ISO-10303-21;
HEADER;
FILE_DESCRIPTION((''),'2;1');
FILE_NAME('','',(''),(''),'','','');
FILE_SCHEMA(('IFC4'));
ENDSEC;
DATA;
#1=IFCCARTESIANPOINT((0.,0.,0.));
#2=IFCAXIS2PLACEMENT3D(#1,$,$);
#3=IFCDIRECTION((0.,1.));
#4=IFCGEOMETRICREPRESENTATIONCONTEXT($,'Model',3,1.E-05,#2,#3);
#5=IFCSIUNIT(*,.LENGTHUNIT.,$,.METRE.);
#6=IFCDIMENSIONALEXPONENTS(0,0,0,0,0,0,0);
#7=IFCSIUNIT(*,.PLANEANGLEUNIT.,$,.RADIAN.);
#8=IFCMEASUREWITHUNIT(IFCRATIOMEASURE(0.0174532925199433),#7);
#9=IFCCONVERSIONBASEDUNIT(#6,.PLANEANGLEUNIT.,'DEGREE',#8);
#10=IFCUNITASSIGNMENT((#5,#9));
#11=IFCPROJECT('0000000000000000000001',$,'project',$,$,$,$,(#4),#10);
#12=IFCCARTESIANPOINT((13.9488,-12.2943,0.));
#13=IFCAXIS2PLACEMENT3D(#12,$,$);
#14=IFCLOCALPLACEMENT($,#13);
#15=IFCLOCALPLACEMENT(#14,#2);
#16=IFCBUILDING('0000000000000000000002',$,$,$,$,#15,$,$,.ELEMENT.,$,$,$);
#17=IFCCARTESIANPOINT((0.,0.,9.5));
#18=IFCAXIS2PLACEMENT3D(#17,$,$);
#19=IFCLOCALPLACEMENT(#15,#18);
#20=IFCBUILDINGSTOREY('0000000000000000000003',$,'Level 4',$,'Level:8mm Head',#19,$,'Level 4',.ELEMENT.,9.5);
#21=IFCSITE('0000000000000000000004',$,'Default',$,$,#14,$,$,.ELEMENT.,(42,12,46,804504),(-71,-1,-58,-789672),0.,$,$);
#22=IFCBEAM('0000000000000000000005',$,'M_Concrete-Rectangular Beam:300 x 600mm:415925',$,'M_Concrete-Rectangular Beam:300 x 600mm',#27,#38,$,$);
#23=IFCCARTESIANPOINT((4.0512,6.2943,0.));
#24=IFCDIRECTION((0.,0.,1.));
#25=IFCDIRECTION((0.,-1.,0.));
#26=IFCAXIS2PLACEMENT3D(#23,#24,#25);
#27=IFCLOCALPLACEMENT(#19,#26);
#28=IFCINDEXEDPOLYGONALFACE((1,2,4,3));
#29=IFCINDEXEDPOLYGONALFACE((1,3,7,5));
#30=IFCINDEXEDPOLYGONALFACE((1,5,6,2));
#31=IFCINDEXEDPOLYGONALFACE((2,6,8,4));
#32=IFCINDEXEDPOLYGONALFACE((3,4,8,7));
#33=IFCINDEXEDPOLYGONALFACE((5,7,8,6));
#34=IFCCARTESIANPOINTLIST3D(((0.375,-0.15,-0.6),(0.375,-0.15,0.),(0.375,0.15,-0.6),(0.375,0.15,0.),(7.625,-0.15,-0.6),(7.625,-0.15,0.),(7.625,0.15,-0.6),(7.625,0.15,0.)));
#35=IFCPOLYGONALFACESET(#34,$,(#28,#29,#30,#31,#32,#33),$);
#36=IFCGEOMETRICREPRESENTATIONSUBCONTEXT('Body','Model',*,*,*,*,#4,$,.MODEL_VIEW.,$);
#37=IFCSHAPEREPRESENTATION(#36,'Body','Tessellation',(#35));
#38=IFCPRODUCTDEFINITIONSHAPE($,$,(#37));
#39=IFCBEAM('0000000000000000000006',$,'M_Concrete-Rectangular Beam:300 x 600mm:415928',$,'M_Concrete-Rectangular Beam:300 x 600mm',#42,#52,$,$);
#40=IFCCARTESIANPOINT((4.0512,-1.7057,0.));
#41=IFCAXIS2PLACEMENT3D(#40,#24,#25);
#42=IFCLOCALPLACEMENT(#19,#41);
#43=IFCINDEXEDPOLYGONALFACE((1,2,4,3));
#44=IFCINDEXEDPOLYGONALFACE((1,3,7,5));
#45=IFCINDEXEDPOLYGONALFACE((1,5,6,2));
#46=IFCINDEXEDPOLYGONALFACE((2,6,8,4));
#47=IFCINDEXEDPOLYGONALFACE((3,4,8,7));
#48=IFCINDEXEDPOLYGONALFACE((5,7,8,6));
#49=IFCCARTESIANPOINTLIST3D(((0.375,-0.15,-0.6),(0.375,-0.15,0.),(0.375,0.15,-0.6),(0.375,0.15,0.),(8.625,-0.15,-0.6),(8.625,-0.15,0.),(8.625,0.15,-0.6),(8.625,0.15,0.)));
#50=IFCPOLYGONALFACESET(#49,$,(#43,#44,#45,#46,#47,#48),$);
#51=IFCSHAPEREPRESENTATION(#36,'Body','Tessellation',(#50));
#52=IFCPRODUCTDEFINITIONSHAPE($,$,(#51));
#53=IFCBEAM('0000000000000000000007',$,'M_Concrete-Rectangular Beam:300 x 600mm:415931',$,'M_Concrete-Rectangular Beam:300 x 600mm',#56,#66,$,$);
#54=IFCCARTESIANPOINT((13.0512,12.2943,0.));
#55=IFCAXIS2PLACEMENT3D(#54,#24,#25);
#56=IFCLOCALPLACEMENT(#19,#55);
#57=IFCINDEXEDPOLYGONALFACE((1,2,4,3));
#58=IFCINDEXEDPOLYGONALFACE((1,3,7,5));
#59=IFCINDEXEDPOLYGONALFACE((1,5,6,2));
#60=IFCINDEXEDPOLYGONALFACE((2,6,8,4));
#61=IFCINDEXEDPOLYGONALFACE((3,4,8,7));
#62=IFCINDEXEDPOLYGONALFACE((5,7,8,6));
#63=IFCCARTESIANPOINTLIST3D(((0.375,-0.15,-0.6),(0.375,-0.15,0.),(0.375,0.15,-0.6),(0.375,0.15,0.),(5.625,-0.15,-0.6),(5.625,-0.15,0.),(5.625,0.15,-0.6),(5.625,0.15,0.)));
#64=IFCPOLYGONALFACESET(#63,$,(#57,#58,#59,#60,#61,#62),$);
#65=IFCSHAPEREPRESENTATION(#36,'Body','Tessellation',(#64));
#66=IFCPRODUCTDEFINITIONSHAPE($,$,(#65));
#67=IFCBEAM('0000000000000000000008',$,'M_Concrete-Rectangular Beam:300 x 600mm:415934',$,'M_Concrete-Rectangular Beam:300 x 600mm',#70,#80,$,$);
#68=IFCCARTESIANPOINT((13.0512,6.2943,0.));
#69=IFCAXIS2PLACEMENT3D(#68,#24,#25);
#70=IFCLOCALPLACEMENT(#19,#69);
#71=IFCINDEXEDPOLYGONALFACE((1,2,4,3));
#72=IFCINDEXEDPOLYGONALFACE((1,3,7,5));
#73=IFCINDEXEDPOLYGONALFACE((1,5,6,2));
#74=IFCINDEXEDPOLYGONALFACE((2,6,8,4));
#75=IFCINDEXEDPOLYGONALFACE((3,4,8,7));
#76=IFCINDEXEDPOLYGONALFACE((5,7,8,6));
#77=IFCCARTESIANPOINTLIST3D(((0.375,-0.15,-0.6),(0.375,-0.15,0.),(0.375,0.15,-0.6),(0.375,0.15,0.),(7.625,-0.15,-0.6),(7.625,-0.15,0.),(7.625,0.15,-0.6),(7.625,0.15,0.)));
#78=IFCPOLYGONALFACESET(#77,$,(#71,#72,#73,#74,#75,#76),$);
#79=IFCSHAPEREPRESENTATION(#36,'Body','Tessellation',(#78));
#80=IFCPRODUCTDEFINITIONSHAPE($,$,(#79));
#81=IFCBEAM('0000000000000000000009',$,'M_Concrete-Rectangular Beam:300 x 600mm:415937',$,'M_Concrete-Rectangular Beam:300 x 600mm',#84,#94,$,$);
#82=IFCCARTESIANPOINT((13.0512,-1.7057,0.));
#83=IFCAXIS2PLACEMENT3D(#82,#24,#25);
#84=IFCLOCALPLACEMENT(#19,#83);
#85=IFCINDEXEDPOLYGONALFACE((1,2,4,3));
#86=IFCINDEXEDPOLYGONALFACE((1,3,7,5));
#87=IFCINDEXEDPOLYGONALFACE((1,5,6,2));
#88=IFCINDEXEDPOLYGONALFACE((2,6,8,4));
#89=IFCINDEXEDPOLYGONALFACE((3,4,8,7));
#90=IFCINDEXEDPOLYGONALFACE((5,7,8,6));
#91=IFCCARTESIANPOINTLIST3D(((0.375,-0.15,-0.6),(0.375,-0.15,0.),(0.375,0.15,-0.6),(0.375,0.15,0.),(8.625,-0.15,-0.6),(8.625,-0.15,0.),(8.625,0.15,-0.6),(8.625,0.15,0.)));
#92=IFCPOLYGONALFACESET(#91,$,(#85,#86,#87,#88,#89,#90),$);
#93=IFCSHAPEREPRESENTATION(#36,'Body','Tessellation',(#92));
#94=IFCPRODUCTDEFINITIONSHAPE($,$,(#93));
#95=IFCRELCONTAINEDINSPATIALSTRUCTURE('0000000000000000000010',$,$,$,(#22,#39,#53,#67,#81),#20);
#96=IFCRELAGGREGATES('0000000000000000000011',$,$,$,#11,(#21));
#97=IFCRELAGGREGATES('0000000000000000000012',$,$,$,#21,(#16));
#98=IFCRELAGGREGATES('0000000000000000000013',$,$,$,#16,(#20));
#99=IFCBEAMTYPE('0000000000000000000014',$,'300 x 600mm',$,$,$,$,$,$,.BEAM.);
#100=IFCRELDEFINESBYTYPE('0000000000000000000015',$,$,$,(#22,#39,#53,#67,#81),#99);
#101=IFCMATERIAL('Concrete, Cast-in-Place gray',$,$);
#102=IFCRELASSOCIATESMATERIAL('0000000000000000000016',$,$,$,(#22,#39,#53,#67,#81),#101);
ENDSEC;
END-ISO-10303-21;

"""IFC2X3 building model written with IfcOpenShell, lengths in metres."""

from ifc_helpers import new_model, entity, si_unit, converted_unit, direction, frame, frame_2d, origin, origin_2d_with_axis, place, context, subcontext, project, spatial, rectangle, extrude, material, type_object, element, save


model = new_model("IFC2X3")

# Units and contexts
model_context = context("Model", 3, precision=1e-05, world=origin(), true_north=direction((0.0, 1.0)))
body_context = subcontext(model_context, "Body", "Model", "MODEL_VIEW")
ifc_project = project(units=[si_unit("LENGTHUNIT", "METRE"), converted_unit("PLANEANGLEUNIT", "DEGREE", entity("IfcRatioMeasure", 0.0174532925199433), si_unit("PLANEANGLEUNIT", "RADIAN"), dimensions=[0, 0, 0, 0, 0, 0, 0])], contexts=[model_context])

# Site, building, storey
site_placement = place(None, frame((13.9488, -12.2943, 0.0)))
site = spatial("IfcSite", under=ifc_project, at=site_placement, Name="Default", CompositionType="ELEMENT", RefLatitude=(42, 12, 46, 804504), RefLongitude=(-71, -1, -58, -789672), RefElevation=0.0)
building_placement = place(site_placement, origin())
building = spatial("IfcBuilding", under=site, at=building_placement, CompositionType="ELEMENT")
storey_placement = place(building_placement, frame((0.0, 0.0, 9.5)))
storey = spatial("IfcBuildingStorey", under=building, at=storey_placement, Name="Level 4", ObjectType="Level:8mm Head", LongName="Level 4", CompositionType="ELEMENT", Elevation=9.5)

# Shared definitions
ifc_material = material(Name="Concrete, Cast-in-Place gray")

# Beams
beam_type_1 = type_object("IfcBeamType", Name="300 x 600mm", PredefinedType="BEAM")
beam_1_placement = place(storey_placement, frame((4.0512, 6.2943, 0.0), z_axis=(0.0, 0.0, 1.0), x_axis=(0.0, -1.0, 0.0)))
element("IfcBeam", 1, at=beam_1_placement, inside=storey, type_object=beam_type_1, material=ifc_material, Name="M_Concrete-Rectangular Beam:300 x 600mm:415925", ObjectType="M_Concrete-Rectangular Beam:300 x 600mm", context=body_context, shape_type="SweptSolid", body=[
    extrude(rectangle(XDim=0.6, YDim=0.3, at=frame_2d((0.0, 0.0), x_axis=(1.0, 0.0))), frame((0.375, 0.0, -0.3), z_axis=(1.0, 0.0, 0.0), x_axis=(0.0, 0.0, -1.0)), (0.0, 0.0, 1.0), 7.25),
])
beam_2_placement = place(storey_placement, frame((4.0512, -1.7057, 0.0), z_axis=(0.0, 0.0, 1.0), x_axis=(0.0, -1.0, 0.0)))
element("IfcBeam", 2, at=beam_2_placement, inside=storey, type_object=beam_type_1, material=ifc_material, Name="M_Concrete-Rectangular Beam:300 x 600mm:415928", ObjectType="M_Concrete-Rectangular Beam:300 x 600mm", context=body_context, shape_type="SweptSolid", body=[
    extrude(rectangle(XDim=0.6, YDim=0.3, at=frame_2d((0.0, 0.0), x_axis=(1.0, 0.0))), frame((0.375, 0.0, -0.3), z_axis=(1.0, 0.0, 0.0), x_axis=(0.0, 0.0, -1.0)), (0.0, 0.0, 1.0), 8.25),
])
beam_3_placement = place(storey_placement, frame((13.0512, 12.2943, 0.0), z_axis=(0.0, 0.0, 1.0), x_axis=(0.0, -1.0, 0.0)))
element("IfcBeam", 3, at=beam_3_placement, inside=storey, type_object=beam_type_1, material=ifc_material, Name="M_Concrete-Rectangular Beam:300 x 600mm:415931", ObjectType="M_Concrete-Rectangular Beam:300 x 600mm", context=body_context, shape_type="SweptSolid", body=[
    extrude(rectangle(XDim=0.6, YDim=0.3, at=origin_2d_with_axis()), frame((0.375, 0.0, -0.3), z_axis=(1.0, 0.0, 0.0), x_axis=(0.0, 0.0, -1.0)), (0.0, 0.0, 1.0), 5.25),
])
beam_4_placement = place(storey_placement, frame((13.0512, 6.2943, 0.0), z_axis=(0.0, 0.0, 1.0), x_axis=(0.0, -1.0, 0.0)))
element("IfcBeam", 4, at=beam_4_placement, inside=storey, type_object=beam_type_1, material=ifc_material, Name="M_Concrete-Rectangular Beam:300 x 600mm:415934", ObjectType="M_Concrete-Rectangular Beam:300 x 600mm", context=body_context, shape_type="SweptSolid", body=[
    extrude(rectangle(XDim=0.6, YDim=0.3, at=frame_2d((0.0, 0.0), x_axis=(1.0, 0.0))), frame((0.375, 0.0, -0.3), z_axis=(1.0, 0.0, 0.0), x_axis=(0.0, 0.0, -1.0)), (0.0, 0.0, 1.0), 7.25),
])
beam_5_placement = place(storey_placement, frame((13.0512, -1.7057, 0.0), z_axis=(0.0, 0.0, 1.0), x_axis=(0.0, -1.0, 0.0)))
element("IfcBeam", 5, at=beam_5_placement, inside=storey, type_object=beam_type_1, material=ifc_material, Name="M_Concrete-Rectangular Beam:300 x 600mm:415937", ObjectType="M_Concrete-Rectangular Beam:300 x 600mm", context=body_context, shape_type="SweptSolid", body=[
    extrude(rectangle(XDim=0.6, YDim=0.3, at=frame_2d((0.0, 0.0), x_axis=(1.0, 0.0))), frame((0.375, 0.0, -0.3), z_axis=(1.0, 0.0, 0.0), x_axis=(0.0, 0.0, -1.0)), (0.0, 0.0, 1.0), 8.25),
])

save(model, "model.ifc")
